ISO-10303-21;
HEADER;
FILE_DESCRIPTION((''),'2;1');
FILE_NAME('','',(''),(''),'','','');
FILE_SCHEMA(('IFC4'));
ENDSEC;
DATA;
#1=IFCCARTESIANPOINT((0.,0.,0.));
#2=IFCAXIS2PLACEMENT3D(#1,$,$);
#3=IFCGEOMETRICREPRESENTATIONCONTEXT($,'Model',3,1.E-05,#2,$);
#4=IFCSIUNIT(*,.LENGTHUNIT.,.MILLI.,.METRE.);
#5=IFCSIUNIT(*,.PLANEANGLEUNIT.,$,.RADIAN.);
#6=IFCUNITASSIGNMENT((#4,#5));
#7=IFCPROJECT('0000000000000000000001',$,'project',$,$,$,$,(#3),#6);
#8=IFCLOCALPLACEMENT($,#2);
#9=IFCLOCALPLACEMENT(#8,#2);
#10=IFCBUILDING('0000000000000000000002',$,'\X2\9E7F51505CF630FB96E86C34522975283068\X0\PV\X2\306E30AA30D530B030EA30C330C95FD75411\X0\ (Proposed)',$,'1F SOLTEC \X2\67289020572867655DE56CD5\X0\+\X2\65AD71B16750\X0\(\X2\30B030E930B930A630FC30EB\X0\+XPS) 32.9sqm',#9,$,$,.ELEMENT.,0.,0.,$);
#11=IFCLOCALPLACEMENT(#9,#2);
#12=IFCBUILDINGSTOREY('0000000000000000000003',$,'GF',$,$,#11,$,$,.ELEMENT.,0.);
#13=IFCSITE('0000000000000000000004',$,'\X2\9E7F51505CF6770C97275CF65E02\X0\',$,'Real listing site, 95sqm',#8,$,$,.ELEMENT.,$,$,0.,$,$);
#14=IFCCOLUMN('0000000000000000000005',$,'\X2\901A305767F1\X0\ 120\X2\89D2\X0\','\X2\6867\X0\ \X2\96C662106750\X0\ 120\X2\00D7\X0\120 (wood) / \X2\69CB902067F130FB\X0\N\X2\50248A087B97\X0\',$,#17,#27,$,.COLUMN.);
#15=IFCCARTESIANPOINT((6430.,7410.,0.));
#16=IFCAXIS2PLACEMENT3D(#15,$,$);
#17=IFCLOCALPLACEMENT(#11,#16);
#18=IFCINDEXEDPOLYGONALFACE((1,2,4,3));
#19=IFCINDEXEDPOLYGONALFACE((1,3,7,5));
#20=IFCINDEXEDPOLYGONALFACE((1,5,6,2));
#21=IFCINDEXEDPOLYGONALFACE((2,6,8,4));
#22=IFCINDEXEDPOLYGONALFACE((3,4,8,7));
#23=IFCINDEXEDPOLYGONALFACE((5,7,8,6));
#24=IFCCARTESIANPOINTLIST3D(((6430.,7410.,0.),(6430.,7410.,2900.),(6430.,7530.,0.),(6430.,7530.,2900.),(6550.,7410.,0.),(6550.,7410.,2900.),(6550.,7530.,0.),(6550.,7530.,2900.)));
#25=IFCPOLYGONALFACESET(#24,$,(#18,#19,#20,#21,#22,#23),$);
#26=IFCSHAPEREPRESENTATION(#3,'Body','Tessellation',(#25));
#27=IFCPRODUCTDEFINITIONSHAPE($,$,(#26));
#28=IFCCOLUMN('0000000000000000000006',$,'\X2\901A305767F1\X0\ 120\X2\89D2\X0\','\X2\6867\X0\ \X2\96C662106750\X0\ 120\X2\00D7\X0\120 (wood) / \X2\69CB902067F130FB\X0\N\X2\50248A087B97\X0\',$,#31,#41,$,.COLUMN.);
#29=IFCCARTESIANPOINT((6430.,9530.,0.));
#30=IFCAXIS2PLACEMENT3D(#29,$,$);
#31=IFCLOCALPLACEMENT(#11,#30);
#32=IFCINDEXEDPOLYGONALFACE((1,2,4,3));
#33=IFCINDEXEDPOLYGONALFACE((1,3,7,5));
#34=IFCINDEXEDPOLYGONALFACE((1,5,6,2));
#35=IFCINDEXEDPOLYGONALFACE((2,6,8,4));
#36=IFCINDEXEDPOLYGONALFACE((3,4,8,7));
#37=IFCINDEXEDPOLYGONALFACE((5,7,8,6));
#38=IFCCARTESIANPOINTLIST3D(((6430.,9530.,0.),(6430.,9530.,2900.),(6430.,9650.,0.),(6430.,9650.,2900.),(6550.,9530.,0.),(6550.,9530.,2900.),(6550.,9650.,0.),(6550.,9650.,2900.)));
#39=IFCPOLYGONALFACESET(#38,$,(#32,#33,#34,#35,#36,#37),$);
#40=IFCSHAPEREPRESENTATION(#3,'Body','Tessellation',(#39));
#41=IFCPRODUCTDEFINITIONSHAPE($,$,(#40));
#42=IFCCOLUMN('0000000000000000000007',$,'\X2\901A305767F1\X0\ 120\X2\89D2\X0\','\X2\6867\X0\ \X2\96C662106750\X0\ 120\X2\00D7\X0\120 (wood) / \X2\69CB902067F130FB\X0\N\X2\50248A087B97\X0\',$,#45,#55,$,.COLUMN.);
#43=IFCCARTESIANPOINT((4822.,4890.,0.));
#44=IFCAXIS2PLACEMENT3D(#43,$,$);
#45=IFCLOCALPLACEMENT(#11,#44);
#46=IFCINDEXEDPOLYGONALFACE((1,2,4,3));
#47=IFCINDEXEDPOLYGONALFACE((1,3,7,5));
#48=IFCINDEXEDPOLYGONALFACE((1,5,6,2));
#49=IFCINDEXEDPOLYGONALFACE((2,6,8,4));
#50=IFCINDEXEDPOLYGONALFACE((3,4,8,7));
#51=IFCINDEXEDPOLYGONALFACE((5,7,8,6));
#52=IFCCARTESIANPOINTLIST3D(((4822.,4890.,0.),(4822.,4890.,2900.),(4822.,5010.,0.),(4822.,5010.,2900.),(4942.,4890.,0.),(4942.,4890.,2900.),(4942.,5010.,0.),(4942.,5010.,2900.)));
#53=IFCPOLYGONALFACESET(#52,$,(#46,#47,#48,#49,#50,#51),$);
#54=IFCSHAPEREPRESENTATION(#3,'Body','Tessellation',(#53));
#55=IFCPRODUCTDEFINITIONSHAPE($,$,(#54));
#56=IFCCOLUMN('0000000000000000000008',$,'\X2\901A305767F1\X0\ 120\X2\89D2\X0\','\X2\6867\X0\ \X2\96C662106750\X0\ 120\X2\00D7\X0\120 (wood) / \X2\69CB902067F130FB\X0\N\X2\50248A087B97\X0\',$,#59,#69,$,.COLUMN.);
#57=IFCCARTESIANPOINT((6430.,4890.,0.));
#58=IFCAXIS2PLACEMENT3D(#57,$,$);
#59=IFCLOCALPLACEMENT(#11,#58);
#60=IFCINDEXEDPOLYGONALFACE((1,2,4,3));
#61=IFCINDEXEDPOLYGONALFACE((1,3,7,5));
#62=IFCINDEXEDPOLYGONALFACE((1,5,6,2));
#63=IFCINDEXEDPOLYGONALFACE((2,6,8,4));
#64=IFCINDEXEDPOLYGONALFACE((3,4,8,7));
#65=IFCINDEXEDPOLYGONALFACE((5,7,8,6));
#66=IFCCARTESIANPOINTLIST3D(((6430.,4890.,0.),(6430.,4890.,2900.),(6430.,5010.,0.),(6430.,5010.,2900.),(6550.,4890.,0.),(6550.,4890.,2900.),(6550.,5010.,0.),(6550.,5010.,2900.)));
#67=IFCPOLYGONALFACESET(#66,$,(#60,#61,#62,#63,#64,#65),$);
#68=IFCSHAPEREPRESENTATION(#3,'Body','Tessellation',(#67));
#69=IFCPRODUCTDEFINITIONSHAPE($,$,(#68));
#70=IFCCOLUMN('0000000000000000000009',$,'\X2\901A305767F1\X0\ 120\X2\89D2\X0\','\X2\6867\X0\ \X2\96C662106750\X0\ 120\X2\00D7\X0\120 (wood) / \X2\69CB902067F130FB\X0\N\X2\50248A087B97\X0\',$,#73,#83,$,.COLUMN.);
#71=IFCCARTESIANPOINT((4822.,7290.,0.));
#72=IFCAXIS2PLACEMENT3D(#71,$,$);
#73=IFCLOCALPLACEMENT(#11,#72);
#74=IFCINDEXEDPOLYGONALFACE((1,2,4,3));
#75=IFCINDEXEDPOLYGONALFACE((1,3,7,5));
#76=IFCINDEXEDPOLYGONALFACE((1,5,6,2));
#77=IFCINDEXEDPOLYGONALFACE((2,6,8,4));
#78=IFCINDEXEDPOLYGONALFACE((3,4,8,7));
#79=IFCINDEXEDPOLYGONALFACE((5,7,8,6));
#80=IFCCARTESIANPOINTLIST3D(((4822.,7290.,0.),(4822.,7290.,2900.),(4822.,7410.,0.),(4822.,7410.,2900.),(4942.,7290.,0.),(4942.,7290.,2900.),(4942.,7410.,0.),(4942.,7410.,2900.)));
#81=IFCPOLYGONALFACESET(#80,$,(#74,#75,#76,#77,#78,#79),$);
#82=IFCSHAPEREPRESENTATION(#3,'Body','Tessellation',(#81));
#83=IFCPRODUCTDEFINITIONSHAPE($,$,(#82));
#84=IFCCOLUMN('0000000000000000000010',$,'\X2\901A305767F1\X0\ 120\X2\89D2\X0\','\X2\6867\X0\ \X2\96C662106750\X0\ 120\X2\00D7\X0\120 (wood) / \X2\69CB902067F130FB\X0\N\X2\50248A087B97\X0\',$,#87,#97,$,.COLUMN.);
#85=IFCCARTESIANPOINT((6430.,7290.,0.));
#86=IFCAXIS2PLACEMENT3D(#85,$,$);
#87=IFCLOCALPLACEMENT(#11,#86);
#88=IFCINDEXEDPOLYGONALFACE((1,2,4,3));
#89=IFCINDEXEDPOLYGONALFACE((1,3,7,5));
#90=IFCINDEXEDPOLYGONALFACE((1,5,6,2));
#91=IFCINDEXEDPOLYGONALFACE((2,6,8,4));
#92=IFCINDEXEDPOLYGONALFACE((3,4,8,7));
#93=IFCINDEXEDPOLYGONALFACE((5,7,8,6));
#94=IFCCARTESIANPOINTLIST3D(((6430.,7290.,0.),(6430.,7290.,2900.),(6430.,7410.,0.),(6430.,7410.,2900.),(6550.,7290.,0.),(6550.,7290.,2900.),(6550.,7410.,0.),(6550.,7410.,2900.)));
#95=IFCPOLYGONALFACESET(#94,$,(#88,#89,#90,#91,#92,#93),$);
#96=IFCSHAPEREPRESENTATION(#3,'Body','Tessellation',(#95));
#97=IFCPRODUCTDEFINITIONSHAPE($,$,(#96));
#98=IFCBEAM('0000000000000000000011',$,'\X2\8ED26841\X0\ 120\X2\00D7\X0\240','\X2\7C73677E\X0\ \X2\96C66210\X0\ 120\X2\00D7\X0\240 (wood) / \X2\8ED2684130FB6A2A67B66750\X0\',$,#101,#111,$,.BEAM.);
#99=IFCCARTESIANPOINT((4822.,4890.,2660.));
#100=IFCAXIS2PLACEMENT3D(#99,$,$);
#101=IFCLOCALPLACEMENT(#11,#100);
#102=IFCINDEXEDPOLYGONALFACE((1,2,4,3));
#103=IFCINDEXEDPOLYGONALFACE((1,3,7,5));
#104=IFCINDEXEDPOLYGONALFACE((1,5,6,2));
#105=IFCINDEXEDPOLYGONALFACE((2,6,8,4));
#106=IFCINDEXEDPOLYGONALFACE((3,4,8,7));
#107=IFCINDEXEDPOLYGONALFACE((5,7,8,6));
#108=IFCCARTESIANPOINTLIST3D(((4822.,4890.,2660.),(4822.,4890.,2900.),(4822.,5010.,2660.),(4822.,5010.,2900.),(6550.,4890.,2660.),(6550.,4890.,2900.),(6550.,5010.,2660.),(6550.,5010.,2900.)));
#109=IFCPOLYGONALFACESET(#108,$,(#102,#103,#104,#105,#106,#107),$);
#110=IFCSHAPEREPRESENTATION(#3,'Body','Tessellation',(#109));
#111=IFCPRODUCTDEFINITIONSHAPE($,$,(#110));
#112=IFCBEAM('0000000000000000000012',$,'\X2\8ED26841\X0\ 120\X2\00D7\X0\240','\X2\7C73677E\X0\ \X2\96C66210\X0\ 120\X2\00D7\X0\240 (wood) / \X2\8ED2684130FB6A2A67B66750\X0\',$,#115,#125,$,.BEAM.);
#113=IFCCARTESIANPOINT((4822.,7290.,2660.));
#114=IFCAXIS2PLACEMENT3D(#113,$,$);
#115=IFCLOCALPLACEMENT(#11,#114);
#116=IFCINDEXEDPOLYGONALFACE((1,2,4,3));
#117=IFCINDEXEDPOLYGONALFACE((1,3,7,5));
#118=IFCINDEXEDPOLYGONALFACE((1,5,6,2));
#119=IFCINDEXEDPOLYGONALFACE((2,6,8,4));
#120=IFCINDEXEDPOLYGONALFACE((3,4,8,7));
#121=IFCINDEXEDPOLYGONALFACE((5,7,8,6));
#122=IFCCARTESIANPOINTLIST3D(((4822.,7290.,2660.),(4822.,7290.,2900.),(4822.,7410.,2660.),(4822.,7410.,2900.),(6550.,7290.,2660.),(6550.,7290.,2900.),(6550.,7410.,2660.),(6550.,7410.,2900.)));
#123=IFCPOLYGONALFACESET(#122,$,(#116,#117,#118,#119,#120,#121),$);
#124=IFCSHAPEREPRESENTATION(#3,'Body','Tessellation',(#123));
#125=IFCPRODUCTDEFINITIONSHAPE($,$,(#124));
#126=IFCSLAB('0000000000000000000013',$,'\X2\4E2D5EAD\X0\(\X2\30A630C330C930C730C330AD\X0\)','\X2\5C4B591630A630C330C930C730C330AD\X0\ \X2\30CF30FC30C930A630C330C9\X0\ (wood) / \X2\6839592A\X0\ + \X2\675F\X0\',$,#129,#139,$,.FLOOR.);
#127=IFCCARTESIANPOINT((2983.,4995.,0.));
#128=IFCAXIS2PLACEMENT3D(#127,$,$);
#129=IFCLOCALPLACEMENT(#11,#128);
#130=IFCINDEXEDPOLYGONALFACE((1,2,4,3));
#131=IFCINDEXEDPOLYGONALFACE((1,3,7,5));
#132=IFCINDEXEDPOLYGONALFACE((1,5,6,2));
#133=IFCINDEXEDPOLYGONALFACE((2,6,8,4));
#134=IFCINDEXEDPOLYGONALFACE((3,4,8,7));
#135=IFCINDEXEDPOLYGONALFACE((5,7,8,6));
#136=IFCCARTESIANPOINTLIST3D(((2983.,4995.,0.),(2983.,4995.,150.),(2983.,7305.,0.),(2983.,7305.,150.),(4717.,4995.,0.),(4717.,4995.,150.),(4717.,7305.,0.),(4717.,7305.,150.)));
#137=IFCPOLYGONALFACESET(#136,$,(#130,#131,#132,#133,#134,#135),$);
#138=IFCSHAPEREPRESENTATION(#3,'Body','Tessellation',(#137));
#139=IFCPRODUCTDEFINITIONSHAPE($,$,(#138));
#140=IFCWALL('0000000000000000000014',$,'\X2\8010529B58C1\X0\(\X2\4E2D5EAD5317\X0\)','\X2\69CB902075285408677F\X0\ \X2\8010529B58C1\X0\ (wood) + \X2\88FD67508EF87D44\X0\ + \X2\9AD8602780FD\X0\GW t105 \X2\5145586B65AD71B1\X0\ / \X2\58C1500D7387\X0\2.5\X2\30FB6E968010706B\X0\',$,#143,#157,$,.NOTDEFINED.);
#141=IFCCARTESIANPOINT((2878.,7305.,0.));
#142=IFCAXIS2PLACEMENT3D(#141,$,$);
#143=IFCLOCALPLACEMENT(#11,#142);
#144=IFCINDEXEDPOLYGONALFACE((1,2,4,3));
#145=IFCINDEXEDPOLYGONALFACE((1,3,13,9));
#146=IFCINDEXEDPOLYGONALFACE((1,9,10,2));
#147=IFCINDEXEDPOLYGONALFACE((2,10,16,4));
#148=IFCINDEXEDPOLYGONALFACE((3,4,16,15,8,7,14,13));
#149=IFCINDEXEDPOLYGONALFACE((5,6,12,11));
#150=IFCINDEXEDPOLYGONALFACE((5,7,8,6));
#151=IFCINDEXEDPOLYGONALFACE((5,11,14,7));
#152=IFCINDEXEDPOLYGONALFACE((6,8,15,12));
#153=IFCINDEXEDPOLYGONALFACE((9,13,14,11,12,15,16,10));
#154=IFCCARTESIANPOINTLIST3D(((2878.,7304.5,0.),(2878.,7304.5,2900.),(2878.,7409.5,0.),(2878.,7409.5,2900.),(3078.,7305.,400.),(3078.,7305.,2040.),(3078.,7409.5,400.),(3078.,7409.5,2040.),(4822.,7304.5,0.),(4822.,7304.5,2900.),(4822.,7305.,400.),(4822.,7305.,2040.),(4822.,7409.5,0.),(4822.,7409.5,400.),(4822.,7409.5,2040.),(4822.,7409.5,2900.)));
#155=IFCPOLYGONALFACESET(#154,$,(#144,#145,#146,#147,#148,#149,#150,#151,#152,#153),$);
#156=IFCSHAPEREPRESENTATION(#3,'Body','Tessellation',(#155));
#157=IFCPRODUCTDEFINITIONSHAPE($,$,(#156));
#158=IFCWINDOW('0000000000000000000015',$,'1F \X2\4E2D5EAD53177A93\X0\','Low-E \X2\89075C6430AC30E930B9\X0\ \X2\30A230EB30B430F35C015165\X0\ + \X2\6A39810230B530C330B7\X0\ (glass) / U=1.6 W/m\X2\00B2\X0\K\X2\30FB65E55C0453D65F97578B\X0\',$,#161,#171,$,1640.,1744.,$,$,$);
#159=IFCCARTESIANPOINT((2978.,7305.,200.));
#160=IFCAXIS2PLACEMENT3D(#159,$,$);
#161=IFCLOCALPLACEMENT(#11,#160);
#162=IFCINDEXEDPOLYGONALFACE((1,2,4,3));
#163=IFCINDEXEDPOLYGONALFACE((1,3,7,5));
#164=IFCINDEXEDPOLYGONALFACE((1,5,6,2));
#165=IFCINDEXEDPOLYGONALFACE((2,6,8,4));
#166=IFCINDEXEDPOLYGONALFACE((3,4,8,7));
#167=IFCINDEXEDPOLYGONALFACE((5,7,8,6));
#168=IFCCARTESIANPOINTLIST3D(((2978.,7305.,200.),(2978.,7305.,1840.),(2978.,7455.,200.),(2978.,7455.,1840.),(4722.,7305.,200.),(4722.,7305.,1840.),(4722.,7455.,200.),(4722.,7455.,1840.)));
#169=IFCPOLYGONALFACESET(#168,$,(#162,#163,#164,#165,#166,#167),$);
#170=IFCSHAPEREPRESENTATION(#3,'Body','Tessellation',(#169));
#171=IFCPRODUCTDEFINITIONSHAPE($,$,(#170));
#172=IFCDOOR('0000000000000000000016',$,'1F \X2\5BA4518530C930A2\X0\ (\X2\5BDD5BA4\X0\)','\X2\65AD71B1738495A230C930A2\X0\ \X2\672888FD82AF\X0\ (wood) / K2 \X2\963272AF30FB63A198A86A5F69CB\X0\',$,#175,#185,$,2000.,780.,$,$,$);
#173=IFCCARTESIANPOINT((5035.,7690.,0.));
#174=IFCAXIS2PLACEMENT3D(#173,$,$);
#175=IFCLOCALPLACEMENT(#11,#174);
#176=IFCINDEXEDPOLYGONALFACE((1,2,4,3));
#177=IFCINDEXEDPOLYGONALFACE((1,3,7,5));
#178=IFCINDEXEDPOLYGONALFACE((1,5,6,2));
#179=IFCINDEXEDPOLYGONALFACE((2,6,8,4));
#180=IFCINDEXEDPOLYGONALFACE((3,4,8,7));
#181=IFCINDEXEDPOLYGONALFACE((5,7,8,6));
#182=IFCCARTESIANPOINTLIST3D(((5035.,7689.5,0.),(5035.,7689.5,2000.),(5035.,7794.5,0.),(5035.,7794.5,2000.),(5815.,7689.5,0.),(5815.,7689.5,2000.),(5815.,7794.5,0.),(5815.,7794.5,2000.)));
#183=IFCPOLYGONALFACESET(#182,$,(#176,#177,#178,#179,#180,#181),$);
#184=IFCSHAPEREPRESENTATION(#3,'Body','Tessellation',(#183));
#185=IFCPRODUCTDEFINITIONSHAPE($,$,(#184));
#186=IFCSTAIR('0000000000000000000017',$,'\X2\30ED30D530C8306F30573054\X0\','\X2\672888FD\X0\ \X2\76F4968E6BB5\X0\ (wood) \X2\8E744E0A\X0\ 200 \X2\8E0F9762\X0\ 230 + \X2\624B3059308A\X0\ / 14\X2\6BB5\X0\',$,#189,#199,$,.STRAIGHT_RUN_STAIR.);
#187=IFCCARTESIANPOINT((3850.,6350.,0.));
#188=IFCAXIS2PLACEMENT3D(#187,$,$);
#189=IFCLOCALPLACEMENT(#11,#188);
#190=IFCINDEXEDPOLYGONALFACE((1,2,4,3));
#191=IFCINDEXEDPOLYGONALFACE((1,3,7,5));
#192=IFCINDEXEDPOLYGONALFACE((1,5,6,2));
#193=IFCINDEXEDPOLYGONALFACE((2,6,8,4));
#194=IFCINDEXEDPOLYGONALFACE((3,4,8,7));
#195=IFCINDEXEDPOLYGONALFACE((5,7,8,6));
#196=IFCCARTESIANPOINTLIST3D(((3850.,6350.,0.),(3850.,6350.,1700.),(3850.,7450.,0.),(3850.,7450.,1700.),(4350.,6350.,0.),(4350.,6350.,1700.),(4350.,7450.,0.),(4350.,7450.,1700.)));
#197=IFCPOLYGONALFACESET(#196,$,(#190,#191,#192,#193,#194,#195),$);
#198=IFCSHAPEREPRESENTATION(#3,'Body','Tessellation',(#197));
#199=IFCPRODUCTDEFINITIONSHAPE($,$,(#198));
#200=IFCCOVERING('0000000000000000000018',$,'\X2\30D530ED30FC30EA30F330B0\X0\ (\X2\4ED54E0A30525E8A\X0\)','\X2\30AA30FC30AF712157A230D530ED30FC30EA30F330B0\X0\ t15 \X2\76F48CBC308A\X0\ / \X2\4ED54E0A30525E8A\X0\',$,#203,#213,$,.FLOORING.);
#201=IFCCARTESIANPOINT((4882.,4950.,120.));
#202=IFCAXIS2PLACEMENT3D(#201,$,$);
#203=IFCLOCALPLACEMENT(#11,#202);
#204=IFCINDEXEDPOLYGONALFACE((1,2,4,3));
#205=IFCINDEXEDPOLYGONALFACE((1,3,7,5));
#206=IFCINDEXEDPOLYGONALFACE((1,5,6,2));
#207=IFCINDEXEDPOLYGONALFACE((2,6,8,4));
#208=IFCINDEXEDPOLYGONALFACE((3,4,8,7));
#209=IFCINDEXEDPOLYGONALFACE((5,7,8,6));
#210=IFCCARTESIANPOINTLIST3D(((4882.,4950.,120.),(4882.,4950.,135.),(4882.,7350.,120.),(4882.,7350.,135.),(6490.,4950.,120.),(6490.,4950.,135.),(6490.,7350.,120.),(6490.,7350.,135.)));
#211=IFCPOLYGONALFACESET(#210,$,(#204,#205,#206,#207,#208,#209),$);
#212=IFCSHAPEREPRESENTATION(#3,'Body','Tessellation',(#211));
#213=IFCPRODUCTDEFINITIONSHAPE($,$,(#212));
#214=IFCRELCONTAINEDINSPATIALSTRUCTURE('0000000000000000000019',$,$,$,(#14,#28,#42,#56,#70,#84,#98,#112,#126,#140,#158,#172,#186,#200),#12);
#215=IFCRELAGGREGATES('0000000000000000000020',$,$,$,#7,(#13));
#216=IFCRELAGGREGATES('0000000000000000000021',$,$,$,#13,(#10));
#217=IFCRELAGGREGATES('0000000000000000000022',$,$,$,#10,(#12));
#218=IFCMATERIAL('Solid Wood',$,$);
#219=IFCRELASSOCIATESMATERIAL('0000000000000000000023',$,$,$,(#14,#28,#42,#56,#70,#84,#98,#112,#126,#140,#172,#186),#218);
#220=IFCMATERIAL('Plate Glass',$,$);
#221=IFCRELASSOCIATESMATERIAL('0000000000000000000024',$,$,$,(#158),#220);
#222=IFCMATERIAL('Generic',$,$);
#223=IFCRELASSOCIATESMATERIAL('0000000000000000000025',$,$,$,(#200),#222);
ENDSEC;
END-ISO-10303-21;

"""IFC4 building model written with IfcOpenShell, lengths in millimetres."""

from ifc_helpers import new_model, si_unit, frame, frame_2d, origin, place, context, project, spatial, rectangle, extrude, material, element, fill, save


model = new_model("IFC4")

# Units and contexts
model_context = context("Model", 3, precision=1e-05, world=origin())
ifc_project = project(units=[si_unit("LENGTHUNIT", "METRE", prefix="MILLI"), si_unit("PLANEANGLEUNIT", "RADIAN")], contexts=[model_context])

# Site, building, storey
site_placement = place(None, origin())
site = spatial("IfcSite", under=ifc_project, at=site_placement, Name="鹿児島県霧島市", ObjectType="Real listing site, 95sqm", CompositionType="ELEMENT", RefElevation=0.0)
building_placement = place(site_placement, origin())
building = spatial("IfcBuilding", under=site, at=building_placement, Name="鹿児島・雨水利用とPVのオフグリッド志向 (Proposed)", ObjectType="1F SOLTEC 木造在来工法+断熱材(グラスウール+XPS) 32.9sqm", CompositionType="ELEMENT", ElevationOfRefHeight=0.0, ElevationOfTerrain=0.0)
storey_placement = place(building_placement, origin())
storey = spatial("IfcBuildingStorey", under=building, at=storey_placement, Name="GF", CompositionType="ELEMENT", Elevation=0.0)

# Columns
ifc_material_1 = material(Name="Solid Wood")
column_1_placement = place(storey_placement, frame((6430.0, 7410.0, 0.0)))
element("IfcColumn", 1, at=column_1_placement, inside=storey, material=ifc_material_1, Name="通し柱 120角", Description="桧 集成材 120×120 (wood) / 構造柱・N値計算", PredefinedType="COLUMN", context=model_context, shape_type="SweptSolid", body=[
    extrude(rectangle(XDim=120.0, YDim=120.0, at=frame_2d((60.0, 60.0))), frame((6430.0, 7410.0, 0.0)), (0.0, 0.0, 1.0), 2900.0),
])
column_2_placement = place(storey_placement, frame((6430.0, 9530.0, 0.0)))
element("IfcColumn", 2, at=column_2_placement, inside=storey, material=ifc_material_1, Name="通し柱 120角", Description="桧 集成材 120×120 (wood) / 構造柱・N値計算", PredefinedType="COLUMN", context=model_context, shape_type="SweptSolid", body=[
    extrude(rectangle(XDim=120.0, YDim=120.0, at=frame_2d((60.0, 60.0))), frame((6430.0, 9530.0, 0.0)), (0.0, 0.0, 1.0), 2900.0),
])
column_3_placement = place(storey_placement, frame((4822.0, 4890.0, 0.0)))
element("IfcColumn", 3, at=column_3_placement, inside=storey, material=ifc_material_1, Name="通し柱 120角", Description="桧 集成材 120×120 (wood) / 構造柱・N値計算", PredefinedType="COLUMN", context=model_context, shape_type="SweptSolid", body=[
    extrude(rectangle(XDim=120.0, YDim=120.0, at=frame_2d((60.0, 60.0))), frame((4822.0, 4890.0, 0.0)), (0.0, 0.0, 1.0), 2900.0),
])
column_4_placement = place(storey_placement, frame((6430.0, 4890.0, 0.0)))
element("IfcColumn", 4, at=column_4_placement, inside=storey, material=ifc_material_1, Name="通し柱 120角", Description="桧 集成材 120×120 (wood) / 構造柱・N値計算", PredefinedType="COLUMN", context=model_context, shape_type="SweptSolid", body=[
    extrude(rectangle(XDim=120.0, YDim=120.0, at=frame_2d((60.0, 60.0))), frame((6430.0, 4890.0, 0.0)), (0.0, 0.0, 1.0), 2900.0),
])
column_5_placement = place(storey_placement, frame((4822.0, 7290.0, 0.0)))
element("IfcColumn", 5, at=column_5_placement, inside=storey, material=ifc_material_1, Name="通し柱 120角", Description="桧 集成材 120×120 (wood) / 構造柱・N値計算", PredefinedType="COLUMN", context=model_context, shape_type="SweptSolid", body=[
    extrude(rectangle(XDim=120.0, YDim=120.0, at=frame_2d((60.0, 60.0))), frame((4822.0, 7290.0, 0.0)), (0.0, 0.0, 1.0), 2900.0),
])
column_6_placement = place(storey_placement, frame((6430.0, 7290.0, 0.0)))
element("IfcColumn", 6, at=column_6_placement, inside=storey, material=ifc_material_1, Name="通し柱 120角", Description="桧 集成材 120×120 (wood) / 構造柱・N値計算", PredefinedType="COLUMN", context=model_context, shape_type="SweptSolid", body=[
    extrude(rectangle(XDim=120.0, YDim=120.0, at=frame_2d((60.0, 60.0))), frame((6430.0, 7290.0, 0.0)), (0.0, 0.0, 1.0), 2900.0),
])

# Beams
beam_1_placement = place(storey_placement, frame((4822.0, 4890.0, 2660.0)))
element("IfcBeam", 7, at=beam_1_placement, inside=storey, material=ifc_material_1, Name="軒桁 120×240", Description="米松 集成 120×240 (wood) / 軒桁・横架材", PredefinedType="BEAM", context=model_context, shape_type="SweptSolid", body=[
    extrude(rectangle(XDim=1728.0, YDim=120.0, at=frame_2d((864.0, 60.0))), frame((4822.0, 4890.0, 2660.0)), (0.0, 0.0, 1.0), 240.0),
])
beam_2_placement = place(storey_placement, frame((4822.0, 7290.0, 2660.0)))
element("IfcBeam", 8, at=beam_2_placement, inside=storey, material=ifc_material_1, Name="軒桁 120×240", Description="米松 集成 120×240 (wood) / 軒桁・横架材", PredefinedType="BEAM", context=model_context, shape_type="SweptSolid", body=[
    extrude(rectangle(XDim=1728.0, YDim=120.0, at=frame_2d((864.0, 60.0))), frame((4822.0, 7290.0, 2660.0)), (0.0, 0.0, 1.0), 240.0),
])

# Slab
slab_placement = place(storey_placement, frame((2983.0, 4995.0, 0.0)))
element("IfcSlab", 9, at=slab_placement, inside=storey, material=ifc_material_1, Name="中庭(ウッドデッキ)", Description="屋外ウッドデッキ ハードウッド (wood) / 根太 + 束", PredefinedType="FLOOR", context=model_context, shape_type="SweptSolid", body=[
    extrude(rectangle(XDim=1734.0, YDim=2310.0, at=frame_2d((867.0, 1155.0))), frame((2983.0, 4995.0, 0.0)), (0.0, 0.0, 1.0), 150.0),
])

# Wall, opening, window
wall_1_placement = place(storey_placement, frame((2878.0, 7305.0, 0.0)))
wall_1 = element("IfcWall", 10, at=wall_1_placement, inside=storey, material=ifc_material_1, Name="耐力壁(中庭北)", Description="構造用合板 耐力壁 (wood) + 製材軸組 + 高性能GW t105 充填断熱 / 壁倍率2.5・準耐火", PredefinedType="NOTDEFINED", context=model_context, shape_type="SweptSolid", body=[
    extrude(rectangle(XDim=1944.0, YDim=105.0, at=frame_2d((972.0, 52.0))), frame((2878.0, 7305.0, 0.0)), (0.0, 0.0, 1.0), 2900.0),
])
opening_placement = place(storey_placement, frame((2978.0, 7305.0, 200.0)))
opening = element("IfcOpeningElement", 11, at=opening_placement, cuts=wall_1, PredefinedType="NOTDEFINED", context=model_context, shape_type="SweptSolid", body=[
    extrude(rectangle(XDim=1744.0, YDim=150.0, at=frame_2d((872.0, 75.0))), frame((2978.0, 7305.0, 200.0)), (0.0, 0.0, 1.0), 1640.0),
])
ifc_material_2 = material(Name="Plate Glass")
window_placement = place(storey_placement, frame((2978.0, 7305.0, 200.0)))
window = element("IfcWindow", 12, at=window_placement, inside=storey, material=ifc_material_2, Name="1F 中庭北窓", Description="Low-E 複層ガラス アルゴン封入 + 樹脂サッシ (glass) / U=1.6 W/m²K・日射取得型", OverallHeight=1640.0, OverallWidth=1744.0, context=model_context, shape_type="SweptSolid", body=[
    extrude(rectangle(XDim=1744.0, YDim=150.0, at=frame_2d((872.0, 75.0))), frame((2978.0, 7305.0, 200.0)), (0.0, 0.0, 1.0), 1640.0),
])
fill(opening, window)

# Door
door_placement = place(storey_placement, frame((5035.0, 7690.0, 0.0)))
element("IfcDoor", 13, at=door_placement, inside=storey, material=ifc_material_1, Name="1F 室内ドア (寝室)", Description="断熱玄関ドア 木製芯 (wood) / K2 防犯・採風機構", OverallHeight=2000.0, OverallWidth=780.0, context=model_context, shape_type="SweptSolid", body=[
    extrude(rectangle(XDim=780.0, YDim=105.0, at=frame_2d((390.0, 52.0))), frame((5035.0, 7690.0, 0.0)), (0.0, 0.0, 1.0), 2000.0),
])

# Stair
stair_placement = place(storey_placement, frame((3850.0, 6350.0, 0.0)))
element("IfcStair", 14, at=stair_placement, inside=storey, material=ifc_material_1, Name="ロフトはしご", Description="木製 直階段 (wood) 蹴上 200 踏面 230 + 手すり / 14段", PredefinedType="STRAIGHT_RUN_STAIR", context=model_context, shape_type="SweptSolid", body=[
    extrude(rectangle(XDim=500.0, YDim=1100.0, at=frame_2d((250.0, 550.0))), frame((3850.0, 6350.0, 0.0)), (0.0, 0.0, 1.0), 1700.0),
])

# Covering
ifc_material_3 = material(Name="Generic")
covering_placement = place(storey_placement, frame((4882.0, 4950.0, 120.0)))
element("IfcCovering", 15, at=covering_placement, inside=storey, material=ifc_material_3, Name="フローリング (仕上げ床)", Description="オーク無垢フローリング t15 直貼り / 仕上げ床", PredefinedType="FLOORING", context=model_context, shape_type="SweptSolid", body=[
    extrude(rectangle(XDim=1608.0, YDim=2400.0, at=frame_2d((804.0, 1200.0))), frame((4882.0, 4950.0, 120.0)), (0.0, 0.0, 1.0), 15.0),
])

save(model, "model.ifc")
